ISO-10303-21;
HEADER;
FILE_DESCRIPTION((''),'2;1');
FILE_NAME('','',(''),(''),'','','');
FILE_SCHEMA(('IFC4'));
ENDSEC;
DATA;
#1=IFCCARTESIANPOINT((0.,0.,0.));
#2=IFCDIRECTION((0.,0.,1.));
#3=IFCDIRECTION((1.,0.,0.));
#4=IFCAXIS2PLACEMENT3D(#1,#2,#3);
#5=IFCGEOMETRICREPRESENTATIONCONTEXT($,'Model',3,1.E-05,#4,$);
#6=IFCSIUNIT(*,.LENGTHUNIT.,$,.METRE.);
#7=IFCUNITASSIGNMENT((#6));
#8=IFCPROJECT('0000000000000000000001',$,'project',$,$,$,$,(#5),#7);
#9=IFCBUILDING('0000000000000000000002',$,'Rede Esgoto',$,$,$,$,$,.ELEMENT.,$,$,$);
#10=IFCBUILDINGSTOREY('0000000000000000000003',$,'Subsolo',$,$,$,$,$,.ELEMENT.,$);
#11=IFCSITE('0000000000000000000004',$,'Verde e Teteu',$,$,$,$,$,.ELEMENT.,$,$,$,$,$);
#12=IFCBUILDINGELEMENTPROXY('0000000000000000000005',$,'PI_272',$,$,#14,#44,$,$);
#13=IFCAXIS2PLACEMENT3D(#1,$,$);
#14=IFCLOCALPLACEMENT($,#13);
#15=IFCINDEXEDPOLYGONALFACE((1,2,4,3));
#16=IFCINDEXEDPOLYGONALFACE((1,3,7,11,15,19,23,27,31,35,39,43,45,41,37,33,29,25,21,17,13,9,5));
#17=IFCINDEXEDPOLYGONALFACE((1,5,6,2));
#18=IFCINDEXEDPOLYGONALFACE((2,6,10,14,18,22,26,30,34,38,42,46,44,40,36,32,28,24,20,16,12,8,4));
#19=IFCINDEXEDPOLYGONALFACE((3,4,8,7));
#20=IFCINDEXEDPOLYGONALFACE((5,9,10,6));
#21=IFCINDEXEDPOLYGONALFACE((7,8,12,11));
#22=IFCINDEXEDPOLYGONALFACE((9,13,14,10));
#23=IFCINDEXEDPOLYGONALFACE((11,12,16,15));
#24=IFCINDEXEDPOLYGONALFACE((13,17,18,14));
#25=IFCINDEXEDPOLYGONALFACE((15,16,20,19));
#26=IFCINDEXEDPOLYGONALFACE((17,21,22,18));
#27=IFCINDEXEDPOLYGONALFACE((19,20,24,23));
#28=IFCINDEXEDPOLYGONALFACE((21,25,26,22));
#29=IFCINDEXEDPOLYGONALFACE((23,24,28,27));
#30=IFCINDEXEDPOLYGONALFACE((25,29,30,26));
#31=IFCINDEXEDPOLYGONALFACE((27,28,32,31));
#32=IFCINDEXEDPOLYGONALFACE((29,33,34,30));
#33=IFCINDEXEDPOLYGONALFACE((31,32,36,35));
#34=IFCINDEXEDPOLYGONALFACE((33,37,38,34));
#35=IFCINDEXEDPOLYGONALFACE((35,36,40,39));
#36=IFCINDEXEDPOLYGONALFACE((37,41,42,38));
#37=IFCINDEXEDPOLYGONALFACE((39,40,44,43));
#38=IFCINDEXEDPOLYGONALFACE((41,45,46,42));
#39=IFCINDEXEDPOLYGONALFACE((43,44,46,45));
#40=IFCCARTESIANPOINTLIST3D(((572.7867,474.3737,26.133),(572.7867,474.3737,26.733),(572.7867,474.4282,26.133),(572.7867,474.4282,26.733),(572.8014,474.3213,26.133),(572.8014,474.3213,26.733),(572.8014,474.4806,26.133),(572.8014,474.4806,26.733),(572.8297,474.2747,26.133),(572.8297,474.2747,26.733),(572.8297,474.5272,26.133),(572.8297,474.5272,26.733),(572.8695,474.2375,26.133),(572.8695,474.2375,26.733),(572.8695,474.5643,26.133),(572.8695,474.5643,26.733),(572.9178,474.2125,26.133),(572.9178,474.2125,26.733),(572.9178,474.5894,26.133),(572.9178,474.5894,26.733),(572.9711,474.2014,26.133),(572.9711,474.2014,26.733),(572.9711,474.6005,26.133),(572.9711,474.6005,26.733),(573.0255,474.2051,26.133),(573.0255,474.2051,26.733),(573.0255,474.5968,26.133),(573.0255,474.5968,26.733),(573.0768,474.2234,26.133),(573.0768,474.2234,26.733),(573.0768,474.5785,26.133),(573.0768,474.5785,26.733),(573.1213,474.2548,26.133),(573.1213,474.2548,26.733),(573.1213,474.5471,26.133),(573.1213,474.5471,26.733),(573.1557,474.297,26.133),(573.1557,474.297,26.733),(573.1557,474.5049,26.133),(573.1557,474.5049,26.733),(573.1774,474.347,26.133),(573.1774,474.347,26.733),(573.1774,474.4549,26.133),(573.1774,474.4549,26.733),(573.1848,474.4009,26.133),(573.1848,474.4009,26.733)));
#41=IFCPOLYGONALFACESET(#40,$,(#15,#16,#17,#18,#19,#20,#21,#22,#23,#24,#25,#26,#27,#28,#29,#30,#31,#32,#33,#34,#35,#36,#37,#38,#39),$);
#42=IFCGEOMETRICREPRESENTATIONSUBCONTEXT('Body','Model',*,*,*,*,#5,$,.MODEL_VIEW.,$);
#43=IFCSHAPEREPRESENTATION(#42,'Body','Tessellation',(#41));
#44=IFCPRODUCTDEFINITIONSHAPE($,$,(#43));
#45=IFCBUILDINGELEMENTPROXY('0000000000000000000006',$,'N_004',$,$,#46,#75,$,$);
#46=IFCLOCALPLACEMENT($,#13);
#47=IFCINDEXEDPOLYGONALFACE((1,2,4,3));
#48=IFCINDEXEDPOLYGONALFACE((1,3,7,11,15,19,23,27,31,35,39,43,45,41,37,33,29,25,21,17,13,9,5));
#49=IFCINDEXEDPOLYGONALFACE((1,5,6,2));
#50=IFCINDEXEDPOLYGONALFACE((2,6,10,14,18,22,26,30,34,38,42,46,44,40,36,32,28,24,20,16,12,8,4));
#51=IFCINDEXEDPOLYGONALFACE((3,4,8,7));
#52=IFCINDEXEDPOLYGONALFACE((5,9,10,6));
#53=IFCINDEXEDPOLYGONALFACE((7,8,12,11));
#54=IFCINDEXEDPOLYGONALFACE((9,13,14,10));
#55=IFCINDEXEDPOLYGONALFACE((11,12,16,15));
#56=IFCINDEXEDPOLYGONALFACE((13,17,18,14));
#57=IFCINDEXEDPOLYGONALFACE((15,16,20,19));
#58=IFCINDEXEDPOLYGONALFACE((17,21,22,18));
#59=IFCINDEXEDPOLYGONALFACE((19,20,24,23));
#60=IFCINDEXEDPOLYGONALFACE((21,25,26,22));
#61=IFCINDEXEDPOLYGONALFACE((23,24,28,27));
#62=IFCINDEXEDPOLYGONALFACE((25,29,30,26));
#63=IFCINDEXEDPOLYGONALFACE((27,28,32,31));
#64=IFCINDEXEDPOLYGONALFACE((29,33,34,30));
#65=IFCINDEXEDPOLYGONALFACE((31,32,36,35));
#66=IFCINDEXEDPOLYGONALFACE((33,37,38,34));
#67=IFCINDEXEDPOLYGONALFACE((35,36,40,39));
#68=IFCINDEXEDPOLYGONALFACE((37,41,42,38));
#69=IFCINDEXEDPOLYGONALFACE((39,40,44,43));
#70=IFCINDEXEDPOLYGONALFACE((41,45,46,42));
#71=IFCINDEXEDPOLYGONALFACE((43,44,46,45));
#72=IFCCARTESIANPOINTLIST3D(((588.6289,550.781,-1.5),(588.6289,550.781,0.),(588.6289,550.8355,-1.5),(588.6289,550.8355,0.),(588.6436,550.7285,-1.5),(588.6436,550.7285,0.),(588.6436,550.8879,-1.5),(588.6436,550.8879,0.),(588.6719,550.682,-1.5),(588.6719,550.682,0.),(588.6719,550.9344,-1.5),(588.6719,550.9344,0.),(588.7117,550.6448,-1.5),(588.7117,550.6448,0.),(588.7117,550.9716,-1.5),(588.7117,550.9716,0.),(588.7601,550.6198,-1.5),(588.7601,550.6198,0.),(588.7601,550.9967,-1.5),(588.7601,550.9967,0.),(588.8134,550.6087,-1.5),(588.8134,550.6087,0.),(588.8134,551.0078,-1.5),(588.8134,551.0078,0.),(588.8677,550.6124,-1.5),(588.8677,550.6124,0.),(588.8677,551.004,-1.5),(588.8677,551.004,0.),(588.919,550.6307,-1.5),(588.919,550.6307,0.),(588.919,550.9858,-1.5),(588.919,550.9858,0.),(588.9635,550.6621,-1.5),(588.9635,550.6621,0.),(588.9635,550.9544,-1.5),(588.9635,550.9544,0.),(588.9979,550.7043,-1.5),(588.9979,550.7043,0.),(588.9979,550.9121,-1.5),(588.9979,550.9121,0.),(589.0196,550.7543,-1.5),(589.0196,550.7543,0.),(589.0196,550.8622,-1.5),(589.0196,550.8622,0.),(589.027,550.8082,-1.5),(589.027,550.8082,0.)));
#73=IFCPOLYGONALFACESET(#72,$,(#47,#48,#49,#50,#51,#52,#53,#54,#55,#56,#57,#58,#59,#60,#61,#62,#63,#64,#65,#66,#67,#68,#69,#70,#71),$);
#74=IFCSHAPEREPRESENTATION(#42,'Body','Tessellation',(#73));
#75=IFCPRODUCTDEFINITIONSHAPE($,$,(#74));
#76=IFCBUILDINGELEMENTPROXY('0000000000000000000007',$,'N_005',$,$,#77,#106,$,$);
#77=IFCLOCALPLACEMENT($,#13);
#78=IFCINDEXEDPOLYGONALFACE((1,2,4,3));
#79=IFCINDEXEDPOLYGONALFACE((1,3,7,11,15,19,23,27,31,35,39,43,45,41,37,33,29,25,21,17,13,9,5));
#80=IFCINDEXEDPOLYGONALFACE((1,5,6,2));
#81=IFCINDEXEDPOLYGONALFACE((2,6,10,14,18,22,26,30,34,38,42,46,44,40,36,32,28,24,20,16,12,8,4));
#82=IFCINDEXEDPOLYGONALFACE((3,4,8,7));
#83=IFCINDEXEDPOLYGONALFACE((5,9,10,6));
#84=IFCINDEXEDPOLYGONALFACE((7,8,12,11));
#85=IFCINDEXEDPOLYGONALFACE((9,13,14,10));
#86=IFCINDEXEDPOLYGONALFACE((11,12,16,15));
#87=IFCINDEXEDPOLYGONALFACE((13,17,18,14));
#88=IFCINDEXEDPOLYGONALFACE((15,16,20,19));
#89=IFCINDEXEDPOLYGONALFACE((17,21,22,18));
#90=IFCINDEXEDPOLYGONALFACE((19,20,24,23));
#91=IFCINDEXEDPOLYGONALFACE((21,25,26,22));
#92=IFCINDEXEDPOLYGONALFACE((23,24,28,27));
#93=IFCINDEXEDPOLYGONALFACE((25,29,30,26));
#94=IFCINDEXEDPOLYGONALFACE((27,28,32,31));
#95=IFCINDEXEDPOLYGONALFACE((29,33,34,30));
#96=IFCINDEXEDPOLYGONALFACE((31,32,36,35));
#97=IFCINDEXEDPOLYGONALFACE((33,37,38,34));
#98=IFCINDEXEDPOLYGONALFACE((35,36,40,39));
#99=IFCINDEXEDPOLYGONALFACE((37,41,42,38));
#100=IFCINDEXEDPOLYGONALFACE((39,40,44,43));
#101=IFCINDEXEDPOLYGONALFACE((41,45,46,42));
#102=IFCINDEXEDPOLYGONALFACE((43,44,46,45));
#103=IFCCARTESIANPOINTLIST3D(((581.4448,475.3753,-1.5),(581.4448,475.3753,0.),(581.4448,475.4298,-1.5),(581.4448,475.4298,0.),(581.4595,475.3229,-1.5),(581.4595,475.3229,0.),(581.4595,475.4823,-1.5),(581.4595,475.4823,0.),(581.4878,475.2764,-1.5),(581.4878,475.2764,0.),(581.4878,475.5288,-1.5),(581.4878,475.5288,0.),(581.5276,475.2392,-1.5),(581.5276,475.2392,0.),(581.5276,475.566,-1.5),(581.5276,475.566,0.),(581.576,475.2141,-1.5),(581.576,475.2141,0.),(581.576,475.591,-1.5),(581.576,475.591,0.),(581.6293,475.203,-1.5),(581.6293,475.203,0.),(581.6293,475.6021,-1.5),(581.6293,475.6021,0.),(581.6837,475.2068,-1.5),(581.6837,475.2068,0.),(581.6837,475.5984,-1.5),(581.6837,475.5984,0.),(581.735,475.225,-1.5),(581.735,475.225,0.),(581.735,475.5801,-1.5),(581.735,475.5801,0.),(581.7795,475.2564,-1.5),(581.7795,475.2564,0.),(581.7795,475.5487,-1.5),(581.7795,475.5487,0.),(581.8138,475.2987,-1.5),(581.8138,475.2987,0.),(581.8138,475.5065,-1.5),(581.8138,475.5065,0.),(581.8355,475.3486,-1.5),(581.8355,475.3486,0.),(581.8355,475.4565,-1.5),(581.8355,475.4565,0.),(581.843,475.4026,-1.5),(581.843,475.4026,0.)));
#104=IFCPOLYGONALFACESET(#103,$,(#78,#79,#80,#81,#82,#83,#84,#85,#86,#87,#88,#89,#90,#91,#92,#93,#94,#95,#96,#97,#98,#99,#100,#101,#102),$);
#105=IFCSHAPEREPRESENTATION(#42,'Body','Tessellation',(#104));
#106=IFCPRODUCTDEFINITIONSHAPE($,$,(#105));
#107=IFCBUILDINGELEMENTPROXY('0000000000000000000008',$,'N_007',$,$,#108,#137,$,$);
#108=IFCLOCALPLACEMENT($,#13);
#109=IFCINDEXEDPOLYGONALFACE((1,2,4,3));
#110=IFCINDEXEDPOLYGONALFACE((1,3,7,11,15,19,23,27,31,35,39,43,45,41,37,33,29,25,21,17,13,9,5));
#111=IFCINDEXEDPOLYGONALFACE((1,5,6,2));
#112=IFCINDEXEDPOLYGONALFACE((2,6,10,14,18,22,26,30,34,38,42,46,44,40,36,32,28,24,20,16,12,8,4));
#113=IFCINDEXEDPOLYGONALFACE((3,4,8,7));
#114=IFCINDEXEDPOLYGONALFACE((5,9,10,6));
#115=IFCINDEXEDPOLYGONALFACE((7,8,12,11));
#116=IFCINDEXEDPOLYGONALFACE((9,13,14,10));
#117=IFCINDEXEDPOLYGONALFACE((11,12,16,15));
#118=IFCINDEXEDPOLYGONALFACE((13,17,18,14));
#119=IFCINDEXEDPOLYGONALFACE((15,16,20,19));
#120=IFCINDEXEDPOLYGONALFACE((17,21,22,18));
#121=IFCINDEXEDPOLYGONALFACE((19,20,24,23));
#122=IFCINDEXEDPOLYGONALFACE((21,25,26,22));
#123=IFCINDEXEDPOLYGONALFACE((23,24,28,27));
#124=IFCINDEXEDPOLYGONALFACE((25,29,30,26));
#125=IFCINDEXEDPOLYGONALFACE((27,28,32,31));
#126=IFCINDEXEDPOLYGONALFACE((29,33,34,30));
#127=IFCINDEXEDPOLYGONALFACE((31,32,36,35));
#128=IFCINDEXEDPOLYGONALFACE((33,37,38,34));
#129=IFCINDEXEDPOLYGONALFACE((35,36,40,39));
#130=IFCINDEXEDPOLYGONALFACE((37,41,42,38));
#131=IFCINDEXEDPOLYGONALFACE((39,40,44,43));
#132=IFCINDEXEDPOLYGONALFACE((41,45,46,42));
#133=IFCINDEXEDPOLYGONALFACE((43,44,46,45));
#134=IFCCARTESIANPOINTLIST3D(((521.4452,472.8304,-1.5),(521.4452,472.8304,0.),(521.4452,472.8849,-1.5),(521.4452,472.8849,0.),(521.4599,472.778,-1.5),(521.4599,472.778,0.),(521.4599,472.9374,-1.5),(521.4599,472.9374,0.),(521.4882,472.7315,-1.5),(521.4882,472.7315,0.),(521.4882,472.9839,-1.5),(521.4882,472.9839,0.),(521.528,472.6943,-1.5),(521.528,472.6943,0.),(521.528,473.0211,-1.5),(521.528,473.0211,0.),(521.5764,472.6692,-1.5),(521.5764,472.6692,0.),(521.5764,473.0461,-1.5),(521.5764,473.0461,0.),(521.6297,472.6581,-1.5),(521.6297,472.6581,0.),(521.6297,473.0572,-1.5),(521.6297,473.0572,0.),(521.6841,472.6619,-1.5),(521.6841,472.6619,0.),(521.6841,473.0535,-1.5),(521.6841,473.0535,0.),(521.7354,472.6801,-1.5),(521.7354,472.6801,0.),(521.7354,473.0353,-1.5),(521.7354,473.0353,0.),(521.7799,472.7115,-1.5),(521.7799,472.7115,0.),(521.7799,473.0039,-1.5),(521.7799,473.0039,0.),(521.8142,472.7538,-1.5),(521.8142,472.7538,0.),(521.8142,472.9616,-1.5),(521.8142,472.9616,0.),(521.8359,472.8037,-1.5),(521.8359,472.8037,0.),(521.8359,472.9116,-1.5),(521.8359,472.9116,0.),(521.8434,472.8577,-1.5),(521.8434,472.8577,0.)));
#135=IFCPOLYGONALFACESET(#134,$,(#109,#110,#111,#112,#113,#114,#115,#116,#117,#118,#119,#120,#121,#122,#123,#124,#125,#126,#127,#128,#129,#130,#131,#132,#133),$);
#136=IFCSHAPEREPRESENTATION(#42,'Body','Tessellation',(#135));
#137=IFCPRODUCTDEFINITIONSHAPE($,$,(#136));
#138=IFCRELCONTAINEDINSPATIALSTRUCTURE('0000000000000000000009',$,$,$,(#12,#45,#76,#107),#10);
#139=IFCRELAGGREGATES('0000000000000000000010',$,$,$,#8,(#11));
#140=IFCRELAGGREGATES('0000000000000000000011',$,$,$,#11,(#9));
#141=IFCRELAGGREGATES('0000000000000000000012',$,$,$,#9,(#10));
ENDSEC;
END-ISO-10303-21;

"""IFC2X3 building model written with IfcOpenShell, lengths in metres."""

from ifc_helpers import new_model, si_unit, frame, origin_with_axes, origin_2d, place, context, subcontext, project, spatial, circle, extrude, element, save


model = new_model("IFC2X3")

# Units and contexts
model_context = context("Model", 3, precision=1e-05, world=origin_with_axes())
body_context = subcontext(model_context, "Body", "Model", "MODEL_VIEW")
ifc_project = project(units=[si_unit("LENGTHUNIT", "METRE")], contexts=[model_context])

# Site, building, storey
site = spatial("IfcSite", under=ifc_project, Name="Verde e Teteu", CompositionType="ELEMENT")
building = spatial("IfcBuilding", under=site, Name="Rede Esgoto", CompositionType="ELEMENT")
storey = spatial("IfcBuildingStorey", under=building, Name="Subsolo", CompositionType="ELEMENT")

# Building element proxies
proxy_1_placement = place(None, frame((572.9848, 474.4009, 26.133), z_axis=(0.0, 0.0, 1.0), x_axis=(1.0, 0.0, 0.0)))
element("IfcBuildingElementProxy", 1, at=proxy_1_placement, inside=storey, Name="PI_272", context=body_context, shape_type="SweptSolid", body=[
    extrude(circle(Radius=0.2, at=origin_2d()), origin_with_axes(), (0.0, 0.0, 1.0), 0.6),
])
for number, where, z_axis, x_axis, name in (
    (2, (588.827, 550.8082, -1.5), (0.0, 0.0, 1.0), (1.0, 0.0, 0.0), "N_004"),
    (3, (581.643, 475.4026, -1.5), (0.0, 0.0, 1.0), (1.0, 0.0, 0.0), "N_005"),
    (4, (521.6434, 472.8577, -1.5), (0.0, 0.0, 1.0), (1.0, 0.0, 0.0), "N_007"),
):
    element("IfcBuildingElementProxy", number, at=place(None, frame(where, z_axis=z_axis, x_axis=x_axis)), inside=storey, Name=name, context=body_context, shape_type="SweptSolid", body=[
        extrude(circle(Radius=0.2, at=origin_2d()), origin_with_axes(), (0.0, 0.0, 1.0), 1.5),
    ])

save(model, "model.ifc")
